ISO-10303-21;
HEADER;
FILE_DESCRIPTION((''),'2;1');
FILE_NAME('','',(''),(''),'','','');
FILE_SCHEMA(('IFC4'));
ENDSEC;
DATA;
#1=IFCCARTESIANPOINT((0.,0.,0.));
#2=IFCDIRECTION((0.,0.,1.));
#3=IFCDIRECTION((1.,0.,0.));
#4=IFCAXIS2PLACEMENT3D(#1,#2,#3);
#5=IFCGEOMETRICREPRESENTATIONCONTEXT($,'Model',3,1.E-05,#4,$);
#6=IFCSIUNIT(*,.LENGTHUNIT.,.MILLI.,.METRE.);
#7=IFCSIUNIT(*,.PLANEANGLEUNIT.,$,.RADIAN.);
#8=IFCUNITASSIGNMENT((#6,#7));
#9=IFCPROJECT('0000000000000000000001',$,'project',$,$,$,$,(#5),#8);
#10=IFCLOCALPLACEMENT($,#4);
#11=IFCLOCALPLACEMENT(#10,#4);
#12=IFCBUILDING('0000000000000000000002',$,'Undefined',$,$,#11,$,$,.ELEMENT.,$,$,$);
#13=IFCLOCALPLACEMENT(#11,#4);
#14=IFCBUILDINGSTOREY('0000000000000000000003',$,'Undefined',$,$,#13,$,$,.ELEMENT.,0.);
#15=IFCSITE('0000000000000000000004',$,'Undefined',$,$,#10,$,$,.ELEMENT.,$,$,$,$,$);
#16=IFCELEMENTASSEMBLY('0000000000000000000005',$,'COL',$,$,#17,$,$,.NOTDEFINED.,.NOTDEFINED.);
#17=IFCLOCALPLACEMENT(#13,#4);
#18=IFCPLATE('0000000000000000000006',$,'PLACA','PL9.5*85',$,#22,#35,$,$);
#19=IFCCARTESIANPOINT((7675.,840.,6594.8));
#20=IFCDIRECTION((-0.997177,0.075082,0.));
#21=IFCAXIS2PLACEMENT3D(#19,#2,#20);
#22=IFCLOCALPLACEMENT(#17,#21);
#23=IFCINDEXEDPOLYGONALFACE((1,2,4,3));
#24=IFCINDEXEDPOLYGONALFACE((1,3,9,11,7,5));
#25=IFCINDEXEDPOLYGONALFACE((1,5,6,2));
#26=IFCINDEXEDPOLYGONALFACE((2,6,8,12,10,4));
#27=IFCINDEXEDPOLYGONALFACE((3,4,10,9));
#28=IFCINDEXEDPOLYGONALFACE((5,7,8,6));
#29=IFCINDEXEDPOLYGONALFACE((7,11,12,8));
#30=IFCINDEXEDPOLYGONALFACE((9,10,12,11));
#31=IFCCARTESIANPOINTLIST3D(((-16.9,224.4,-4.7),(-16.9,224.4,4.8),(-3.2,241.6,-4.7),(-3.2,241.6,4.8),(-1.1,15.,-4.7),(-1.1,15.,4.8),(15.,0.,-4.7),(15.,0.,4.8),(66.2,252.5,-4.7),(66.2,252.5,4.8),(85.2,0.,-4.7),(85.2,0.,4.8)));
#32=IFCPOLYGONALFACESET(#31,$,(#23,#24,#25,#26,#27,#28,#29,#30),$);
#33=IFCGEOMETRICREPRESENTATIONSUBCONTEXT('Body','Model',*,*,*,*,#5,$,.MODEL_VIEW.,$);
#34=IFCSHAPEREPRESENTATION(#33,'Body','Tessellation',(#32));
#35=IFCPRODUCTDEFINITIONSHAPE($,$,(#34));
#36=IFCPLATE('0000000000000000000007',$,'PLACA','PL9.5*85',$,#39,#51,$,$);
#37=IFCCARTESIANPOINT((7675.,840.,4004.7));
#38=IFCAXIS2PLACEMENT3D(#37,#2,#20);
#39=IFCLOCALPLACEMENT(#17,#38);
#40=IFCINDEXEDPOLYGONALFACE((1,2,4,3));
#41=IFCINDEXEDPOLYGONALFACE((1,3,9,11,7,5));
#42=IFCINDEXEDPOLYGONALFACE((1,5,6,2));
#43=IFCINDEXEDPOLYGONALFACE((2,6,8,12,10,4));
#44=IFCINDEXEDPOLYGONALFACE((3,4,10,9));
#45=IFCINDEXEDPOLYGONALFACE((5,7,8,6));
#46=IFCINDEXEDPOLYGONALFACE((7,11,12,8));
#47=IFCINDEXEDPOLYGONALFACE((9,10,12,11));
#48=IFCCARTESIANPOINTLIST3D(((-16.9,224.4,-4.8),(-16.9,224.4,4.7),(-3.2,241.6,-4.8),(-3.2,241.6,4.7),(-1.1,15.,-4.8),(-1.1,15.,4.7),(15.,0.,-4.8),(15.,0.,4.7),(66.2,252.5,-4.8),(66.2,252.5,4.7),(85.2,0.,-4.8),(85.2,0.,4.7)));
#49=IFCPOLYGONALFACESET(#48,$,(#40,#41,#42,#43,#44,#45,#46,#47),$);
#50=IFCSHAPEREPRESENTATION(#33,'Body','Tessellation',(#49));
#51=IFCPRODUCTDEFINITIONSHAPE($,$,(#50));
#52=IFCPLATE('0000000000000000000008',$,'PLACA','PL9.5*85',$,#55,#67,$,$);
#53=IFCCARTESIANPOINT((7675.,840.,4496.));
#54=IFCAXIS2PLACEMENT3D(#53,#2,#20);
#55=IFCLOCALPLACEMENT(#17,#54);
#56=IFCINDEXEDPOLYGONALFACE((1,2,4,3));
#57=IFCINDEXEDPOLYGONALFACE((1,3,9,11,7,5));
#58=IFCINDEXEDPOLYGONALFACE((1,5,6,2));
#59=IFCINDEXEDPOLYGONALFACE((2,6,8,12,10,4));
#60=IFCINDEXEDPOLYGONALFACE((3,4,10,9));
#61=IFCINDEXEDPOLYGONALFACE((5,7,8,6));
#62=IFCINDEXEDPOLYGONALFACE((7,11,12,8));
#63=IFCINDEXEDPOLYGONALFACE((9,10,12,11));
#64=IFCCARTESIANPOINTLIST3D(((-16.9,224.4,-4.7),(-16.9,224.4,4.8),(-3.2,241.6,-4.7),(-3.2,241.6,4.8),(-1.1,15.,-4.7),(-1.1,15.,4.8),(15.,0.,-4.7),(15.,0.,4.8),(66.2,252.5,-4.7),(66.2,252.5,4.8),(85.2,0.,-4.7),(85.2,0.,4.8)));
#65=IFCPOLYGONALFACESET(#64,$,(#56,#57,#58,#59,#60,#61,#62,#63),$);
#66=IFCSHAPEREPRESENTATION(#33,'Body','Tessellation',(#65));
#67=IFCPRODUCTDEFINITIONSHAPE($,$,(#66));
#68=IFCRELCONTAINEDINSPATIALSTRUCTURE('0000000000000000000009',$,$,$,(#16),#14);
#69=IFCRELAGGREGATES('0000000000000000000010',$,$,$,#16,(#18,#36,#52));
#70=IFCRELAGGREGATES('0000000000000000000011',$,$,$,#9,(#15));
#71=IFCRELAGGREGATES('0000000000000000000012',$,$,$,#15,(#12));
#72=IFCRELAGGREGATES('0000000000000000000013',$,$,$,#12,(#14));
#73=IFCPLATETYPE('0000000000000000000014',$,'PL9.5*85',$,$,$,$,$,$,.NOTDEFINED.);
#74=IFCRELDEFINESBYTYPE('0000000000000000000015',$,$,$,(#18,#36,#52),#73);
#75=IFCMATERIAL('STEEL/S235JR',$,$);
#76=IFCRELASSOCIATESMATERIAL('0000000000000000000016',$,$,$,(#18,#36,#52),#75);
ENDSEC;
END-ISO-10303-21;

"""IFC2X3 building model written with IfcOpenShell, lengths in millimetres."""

from ifc_helpers import new_model, si_unit, frame, origin_with_axes, place, context, subcontext, project, spatial, polyline, outline, extrude, material, type_object, element, aggregate, save


model = new_model("IFC2X3")

# Units and contexts
model_context = context("Model", 3, precision=1e-05, world=origin_with_axes())
body_context = subcontext(model_context, "Body", "Model", "MODEL_VIEW")
ifc_project = project(units=[si_unit("LENGTHUNIT", "METRE", prefix="MILLI"), si_unit("PLANEANGLEUNIT", "RADIAN")], contexts=[model_context])

# Site, building, storey
site_placement = place(None, origin_with_axes())
site = spatial("IfcSite", under=ifc_project, at=site_placement, Name="Undefined", CompositionType="ELEMENT")
building_placement = place(site_placement, origin_with_axes())
building = spatial("IfcBuilding", under=site, at=building_placement, Name="Undefined", CompositionType="ELEMENT")
storey_placement = place(building_placement, origin_with_axes())
storey = spatial("IfcBuildingStorey", under=building, at=storey_placement, Name="Undefined", CompositionType="ELEMENT", Elevation=0.0)

# Shared definitions
ifc_material_1 = material(Name="STEEL/S235JR")

# Element assembly
assembly_1_placement = place(storey_placement, origin_with_axes())
assembly_1 = element("IfcElementAssembly", 1, at=assembly_1_placement, inside=storey, Name="COL", AssemblyPlace="NOTDEFINED", PredefinedType="NOTDEFINED")

# Plates
plate_type_1 = type_object("IfcPlateType", Name="PL9.5*85", PredefinedType="NOTDEFINED")
plate_1_placement = place(assembly_1_placement, frame((7675.0, 840.0, 6594.8), z_axis=(0.0, 0.0, 1.0), x_axis=(-0.997177, 0.075082, 0.0)))
plate_1 = element("IfcPlate", 2, at=plate_1_placement, type_object=plate_type_1, material=ifc_material_1, Name="PLACA", Description="PL9.5*85", context=body_context, shape_type="SweptSolid", body=[
    extrude(outline(polyline([(-1.1, 15.0), (15.0, 0.0), (85.2, 0.0), (66.2, 252.5), (-3.2, 241.6), (-16.9, 224.4), (-1.1, 15.0)])), frame((0.0, 0.0, -4.7), z_axis=(0.0, 0.0, 1.0), x_axis=(1.0, 0.0, 0.0)), (0.0, 0.0, 1.0), 9.5),
])
plate_2_placement = place(assembly_1_placement, frame((7675.0, 840.0, 4004.7), z_axis=(0.0, 0.0, 1.0), x_axis=(-0.997177, 0.075082, 0.0)))
plate_2 = element("IfcPlate", 3, at=plate_2_placement, type_object=plate_type_1, material=ifc_material_1, Name="PLACA", Description="PL9.5*85", context=body_context, shape_type="SweptSolid", body=[
    extrude(outline(polyline([(-1.1, 15.0), (15.0, 0.0), (85.2, 0.0), (66.2, 252.5), (-3.2, 241.6), (-16.9, 224.4), (-1.1, 15.0)])), frame((0.0, 0.0, -4.7), z_axis=(0.0, 0.0, 1.0), x_axis=(1.0, 0.0, 0.0)), (0.0, 0.0, 1.0), 9.5),
])
plate_3_placement = place(assembly_1_placement, frame((7675.0, 840.0, 4496.0), z_axis=(0.0, 0.0, 1.0), x_axis=(-0.997177, 0.075082, 0.0)))
plate_3 = element("IfcPlate", 4, at=plate_3_placement, type_object=plate_type_1, material=ifc_material_1, Name="PLACA", Description="PL9.5*85", context=body_context, shape_type="SweptSolid", body=[
    extrude(outline(polyline([(-1.1, 15.0), (15.0, 0.0), (85.2, 0.0), (66.2, 252.5), (-3.2, 241.6), (-16.9, 224.4), (-1.1, 15.0)])), frame((0.0, 0.0, -4.7), z_axis=(0.0, 0.0, 1.0), x_axis=(1.0, 0.0, 0.0)), (0.0, 0.0, 1.0), 9.5),
])
aggregate(assembly_1, [plate_1, plate_2, plate_3])

save(model, "model.ifc")
